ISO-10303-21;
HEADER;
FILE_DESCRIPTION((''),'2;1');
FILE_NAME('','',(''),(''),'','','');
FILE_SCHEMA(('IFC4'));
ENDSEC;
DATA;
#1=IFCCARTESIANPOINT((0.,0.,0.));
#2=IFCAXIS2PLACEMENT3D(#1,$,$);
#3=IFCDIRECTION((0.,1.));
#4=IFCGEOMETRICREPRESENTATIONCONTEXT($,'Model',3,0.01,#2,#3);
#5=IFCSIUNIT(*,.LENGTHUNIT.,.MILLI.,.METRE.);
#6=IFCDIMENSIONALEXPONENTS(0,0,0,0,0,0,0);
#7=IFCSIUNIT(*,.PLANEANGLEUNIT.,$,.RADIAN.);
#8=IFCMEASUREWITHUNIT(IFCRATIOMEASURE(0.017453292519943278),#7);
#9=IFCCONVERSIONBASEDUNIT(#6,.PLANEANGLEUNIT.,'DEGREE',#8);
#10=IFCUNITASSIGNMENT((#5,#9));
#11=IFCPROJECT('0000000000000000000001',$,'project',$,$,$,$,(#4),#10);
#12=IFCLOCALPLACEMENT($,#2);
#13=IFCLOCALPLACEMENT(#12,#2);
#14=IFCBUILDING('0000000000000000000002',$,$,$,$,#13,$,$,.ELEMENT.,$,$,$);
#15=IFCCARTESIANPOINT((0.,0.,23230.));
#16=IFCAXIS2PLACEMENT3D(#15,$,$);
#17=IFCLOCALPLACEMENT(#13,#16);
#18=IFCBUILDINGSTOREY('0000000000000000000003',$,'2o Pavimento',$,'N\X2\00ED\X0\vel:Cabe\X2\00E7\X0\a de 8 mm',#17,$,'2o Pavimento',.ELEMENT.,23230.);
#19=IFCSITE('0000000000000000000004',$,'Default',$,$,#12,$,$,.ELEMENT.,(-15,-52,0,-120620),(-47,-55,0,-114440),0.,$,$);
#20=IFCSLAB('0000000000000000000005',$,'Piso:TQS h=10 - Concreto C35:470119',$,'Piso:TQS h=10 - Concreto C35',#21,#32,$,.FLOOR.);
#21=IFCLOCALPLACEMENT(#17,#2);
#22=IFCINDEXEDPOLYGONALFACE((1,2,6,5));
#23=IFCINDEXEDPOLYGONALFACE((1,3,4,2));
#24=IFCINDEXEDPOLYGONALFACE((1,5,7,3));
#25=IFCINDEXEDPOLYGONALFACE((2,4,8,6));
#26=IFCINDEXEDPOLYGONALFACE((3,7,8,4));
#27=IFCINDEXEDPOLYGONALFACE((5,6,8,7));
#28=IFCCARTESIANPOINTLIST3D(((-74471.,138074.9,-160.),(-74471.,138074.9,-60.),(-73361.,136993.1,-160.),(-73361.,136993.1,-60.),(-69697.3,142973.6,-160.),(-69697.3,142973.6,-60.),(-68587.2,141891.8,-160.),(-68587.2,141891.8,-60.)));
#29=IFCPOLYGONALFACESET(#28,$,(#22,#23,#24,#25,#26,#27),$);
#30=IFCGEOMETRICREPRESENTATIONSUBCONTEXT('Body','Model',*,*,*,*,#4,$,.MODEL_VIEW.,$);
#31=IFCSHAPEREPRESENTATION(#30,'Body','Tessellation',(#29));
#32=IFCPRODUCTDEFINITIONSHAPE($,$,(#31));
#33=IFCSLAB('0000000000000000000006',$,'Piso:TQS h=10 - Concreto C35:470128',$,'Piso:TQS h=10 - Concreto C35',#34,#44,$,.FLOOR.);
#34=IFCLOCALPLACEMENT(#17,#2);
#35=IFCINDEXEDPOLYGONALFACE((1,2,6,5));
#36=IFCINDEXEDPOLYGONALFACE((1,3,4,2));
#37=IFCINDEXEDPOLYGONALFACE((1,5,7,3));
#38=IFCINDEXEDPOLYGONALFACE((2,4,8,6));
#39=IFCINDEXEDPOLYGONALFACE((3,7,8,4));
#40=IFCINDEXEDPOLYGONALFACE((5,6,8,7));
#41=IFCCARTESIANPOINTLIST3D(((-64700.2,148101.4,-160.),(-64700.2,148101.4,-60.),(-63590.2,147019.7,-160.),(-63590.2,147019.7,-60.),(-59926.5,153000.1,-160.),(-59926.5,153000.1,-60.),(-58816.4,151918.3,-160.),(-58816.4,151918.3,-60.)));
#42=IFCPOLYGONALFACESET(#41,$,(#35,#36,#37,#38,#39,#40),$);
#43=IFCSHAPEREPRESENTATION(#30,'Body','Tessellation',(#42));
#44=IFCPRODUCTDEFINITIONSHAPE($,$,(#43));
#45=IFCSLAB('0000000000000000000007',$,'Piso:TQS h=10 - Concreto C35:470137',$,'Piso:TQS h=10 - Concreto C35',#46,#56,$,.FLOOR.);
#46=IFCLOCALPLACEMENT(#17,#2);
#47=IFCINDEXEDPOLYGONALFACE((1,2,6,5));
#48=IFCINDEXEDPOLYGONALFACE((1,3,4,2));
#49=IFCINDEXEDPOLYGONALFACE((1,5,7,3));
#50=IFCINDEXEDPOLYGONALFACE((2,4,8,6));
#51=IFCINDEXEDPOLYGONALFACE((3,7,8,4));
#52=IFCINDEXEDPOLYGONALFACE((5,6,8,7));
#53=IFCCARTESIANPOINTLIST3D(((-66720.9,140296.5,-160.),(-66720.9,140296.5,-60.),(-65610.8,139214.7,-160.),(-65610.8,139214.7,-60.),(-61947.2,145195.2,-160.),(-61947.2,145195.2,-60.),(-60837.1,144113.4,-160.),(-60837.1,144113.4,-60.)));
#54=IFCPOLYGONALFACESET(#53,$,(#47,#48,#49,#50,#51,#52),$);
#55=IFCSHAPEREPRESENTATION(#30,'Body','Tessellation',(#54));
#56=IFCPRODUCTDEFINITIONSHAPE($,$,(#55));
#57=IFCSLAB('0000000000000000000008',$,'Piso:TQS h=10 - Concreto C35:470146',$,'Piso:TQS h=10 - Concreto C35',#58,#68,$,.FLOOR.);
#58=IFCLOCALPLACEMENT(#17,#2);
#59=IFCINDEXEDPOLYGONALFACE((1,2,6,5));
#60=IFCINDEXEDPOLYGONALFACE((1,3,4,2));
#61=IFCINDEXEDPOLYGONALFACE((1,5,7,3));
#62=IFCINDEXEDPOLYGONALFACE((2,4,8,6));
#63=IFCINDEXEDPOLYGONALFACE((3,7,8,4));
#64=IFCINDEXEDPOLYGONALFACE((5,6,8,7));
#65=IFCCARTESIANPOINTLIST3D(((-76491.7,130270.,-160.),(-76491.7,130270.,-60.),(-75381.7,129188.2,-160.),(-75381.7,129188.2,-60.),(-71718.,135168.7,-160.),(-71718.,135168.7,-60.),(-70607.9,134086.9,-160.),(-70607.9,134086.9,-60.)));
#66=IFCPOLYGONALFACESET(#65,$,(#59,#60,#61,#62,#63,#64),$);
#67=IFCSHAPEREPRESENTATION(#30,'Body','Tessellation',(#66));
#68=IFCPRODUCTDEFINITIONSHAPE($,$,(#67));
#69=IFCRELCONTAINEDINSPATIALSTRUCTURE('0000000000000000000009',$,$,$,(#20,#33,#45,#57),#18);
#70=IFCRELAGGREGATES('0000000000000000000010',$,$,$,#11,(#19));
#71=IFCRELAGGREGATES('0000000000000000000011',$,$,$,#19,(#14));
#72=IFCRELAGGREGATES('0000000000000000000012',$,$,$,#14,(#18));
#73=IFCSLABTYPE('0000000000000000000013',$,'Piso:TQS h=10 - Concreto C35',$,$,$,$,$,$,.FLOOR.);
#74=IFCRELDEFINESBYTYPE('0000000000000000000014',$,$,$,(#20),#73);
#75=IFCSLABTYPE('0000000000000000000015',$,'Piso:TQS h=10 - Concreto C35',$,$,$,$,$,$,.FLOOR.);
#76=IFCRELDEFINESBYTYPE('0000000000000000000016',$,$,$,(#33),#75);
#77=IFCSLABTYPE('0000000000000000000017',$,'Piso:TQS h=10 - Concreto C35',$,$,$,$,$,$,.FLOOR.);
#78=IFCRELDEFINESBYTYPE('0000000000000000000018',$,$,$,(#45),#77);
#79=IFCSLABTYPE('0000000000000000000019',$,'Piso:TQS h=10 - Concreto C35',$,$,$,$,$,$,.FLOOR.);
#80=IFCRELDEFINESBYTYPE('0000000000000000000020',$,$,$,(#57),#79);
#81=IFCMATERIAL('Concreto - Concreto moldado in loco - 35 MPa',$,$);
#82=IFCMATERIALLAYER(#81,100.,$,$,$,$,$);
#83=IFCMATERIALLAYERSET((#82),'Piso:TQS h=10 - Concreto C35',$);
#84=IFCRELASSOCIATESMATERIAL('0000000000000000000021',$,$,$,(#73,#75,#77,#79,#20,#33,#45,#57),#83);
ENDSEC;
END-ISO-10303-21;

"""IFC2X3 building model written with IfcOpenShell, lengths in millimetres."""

from ifc_helpers import new_model, entity, si_unit, converted_unit, direction, frame, frame_2d, origin, place, context, subcontext, project, spatial, rectangle, extrude, material, layer, layer_set, layer_usage, type_object, element, save


model = new_model("IFC2X3")

# Units and contexts
model_context = context("Model", 3, precision=0.01, world=origin(), true_north=direction((0.0, 1.0)))
body_context = subcontext(model_context, "Body", "Model", "MODEL_VIEW")
ifc_project = project(units=[si_unit("LENGTHUNIT", "METRE", prefix="MILLI"), converted_unit("PLANEANGLEUNIT", "DEGREE", entity("IfcRatioMeasure", 0.017453292519943278), si_unit("PLANEANGLEUNIT", "RADIAN"), dimensions=[0, 0, 0, 0, 0, 0, 0])], contexts=[model_context])

# Site, building, storey
site_placement = place(None, origin())
site = spatial("IfcSite", under=ifc_project, at=site_placement, Name="Default", CompositionType="ELEMENT", RefLatitude=(-15, -52, 0, -120620), RefLongitude=(-47, -55, 0, -114440), RefElevation=0.0)
building_placement = place(site_placement, origin())
building = spatial("IfcBuilding", under=site, at=building_placement, CompositionType="ELEMENT")
storey_placement = place(building_placement, frame((0.0, 0.0, 23230.0)))
storey = spatial("IfcBuildingStorey", under=building, at=storey_placement, Name="2o Pavimento", ObjectType="Nível:Cabeça de 8 mm", LongName="2o Pavimento", CompositionType="ELEMENT", Elevation=23230.0)

# Shared definitions
ifc_material = material(Name="Concreto - Concreto moldado in loco - 35 MPa")

# Slabs
ifc_layer = layer(ifc_material, 100.0)
ifc_layer_set = layer_set([ifc_layer], Name="Piso:TQS h=10 - Concreto C35")
ifc_layer_usage_1 = layer_usage(ifc_layer_set, "AXIS3", "POSITIVE", 0.0)
slab_type_1 = type_object("IfcSlabType", Name="Piso:TQS h=10 - Concreto C35", PredefinedType="FLOOR", material=ifc_layer_set)
slab_1_placement = place(storey_placement, origin())
element("IfcSlab", 1, at=slab_1_placement, inside=storey, type_object=slab_type_1, material=ifc_layer_usage_1, Name="Piso:TQS h=10 - Concreto C35:470119", ObjectType="Piso:TQS h=10 - Concreto C35", PredefinedType="FLOOR", context=body_context, shape_type="SweptSolid", body=[
    extrude(rectangle(XDim=6840.0, YDim=1550.0, at=frame_2d((0.0, 0.0), x_axis=(1.0, 0.0))), frame((-71529.1, 139983.4, -60.0), z_axis=(0.0, 0.0, -1.0), x_axis=(-0.697915, -0.71618, 0.0)), (0.0, 0.0, 1.0), 100.0),
])
ifc_layer_usage_2 = layer_usage(ifc_layer_set, "AXIS3", "POSITIVE", 0.0)
slab_type_2 = type_object("IfcSlabType", Name="Piso:TQS h=10 - Concreto C35", PredefinedType="FLOOR", material=ifc_layer_set)
slab_2_placement = place(storey_placement, origin())
element("IfcSlab", 2, at=slab_2_placement, inside=storey, type_object=slab_type_2, material=ifc_layer_usage_2, Name="Piso:TQS h=10 - Concreto C35:470128", ObjectType="Piso:TQS h=10 - Concreto C35", PredefinedType="FLOOR", context=body_context, shape_type="SweptSolid", body=[
    extrude(rectangle(XDim=6840.0, YDim=1550.0, at=frame_2d((0.0, 0.0), x_axis=(1.0, 0.0))), frame((-61758.3, 150009.9, -60.0), z_axis=(0.0, 0.0, -1.0), x_axis=(-0.697915, -0.71618, 0.0)), (0.0, 0.0, 1.0), 100.0),
])
ifc_layer_usage_3 = layer_usage(ifc_layer_set, "AXIS3", "POSITIVE", 0.0)
slab_type_3 = type_object("IfcSlabType", Name="Piso:TQS h=10 - Concreto C35", PredefinedType="FLOOR", material=ifc_layer_set)
slab_3_placement = place(storey_placement, origin())
element("IfcSlab", 3, at=slab_3_placement, inside=storey, type_object=slab_type_3, material=ifc_layer_usage_3, Name="Piso:TQS h=10 - Concreto C35:470137", ObjectType="Piso:TQS h=10 - Concreto C35", PredefinedType="FLOOR", context=body_context, shape_type="SweptSolid", body=[
    extrude(rectangle(XDim=1550.0, YDim=6840.0, at=frame_2d((0.0, 0.0), x_axis=(1.0, 0.0))), frame((-63779.0, 142205.0, -60.0), z_axis=(0.0, 0.0, -1.0), x_axis=(0.71618, -0.697915, 0.0)), (0.0, 0.0, 1.0), 100.0),
])
ifc_layer_usage_4 = layer_usage(ifc_layer_set, "AXIS3", "POSITIVE", 0.0)
slab_type_4 = type_object("IfcSlabType", Name="Piso:TQS h=10 - Concreto C35", PredefinedType="FLOOR", material=ifc_layer_set)
slab_4_placement = place(storey_placement, origin())
element("IfcSlab", 4, at=slab_4_placement, inside=storey, type_object=slab_type_4, material=ifc_layer_usage_4, Name="Piso:TQS h=10 - Concreto C35:470146", ObjectType="Piso:TQS h=10 - Concreto C35", PredefinedType="FLOOR", context=body_context, shape_type="SweptSolid", body=[
    extrude(rectangle(XDim=6840.0, YDim=1550.0, at=frame_2d((0.0, 0.0), x_axis=(1.0, 0.0))), frame((-73549.8, 132178.4, -60.0), z_axis=(0.0, 0.0, -1.0), x_axis=(-0.697915, -0.71618, 0.0)), (0.0, 0.0, 1.0), 100.0),
])

save(model, "model.ifc")
